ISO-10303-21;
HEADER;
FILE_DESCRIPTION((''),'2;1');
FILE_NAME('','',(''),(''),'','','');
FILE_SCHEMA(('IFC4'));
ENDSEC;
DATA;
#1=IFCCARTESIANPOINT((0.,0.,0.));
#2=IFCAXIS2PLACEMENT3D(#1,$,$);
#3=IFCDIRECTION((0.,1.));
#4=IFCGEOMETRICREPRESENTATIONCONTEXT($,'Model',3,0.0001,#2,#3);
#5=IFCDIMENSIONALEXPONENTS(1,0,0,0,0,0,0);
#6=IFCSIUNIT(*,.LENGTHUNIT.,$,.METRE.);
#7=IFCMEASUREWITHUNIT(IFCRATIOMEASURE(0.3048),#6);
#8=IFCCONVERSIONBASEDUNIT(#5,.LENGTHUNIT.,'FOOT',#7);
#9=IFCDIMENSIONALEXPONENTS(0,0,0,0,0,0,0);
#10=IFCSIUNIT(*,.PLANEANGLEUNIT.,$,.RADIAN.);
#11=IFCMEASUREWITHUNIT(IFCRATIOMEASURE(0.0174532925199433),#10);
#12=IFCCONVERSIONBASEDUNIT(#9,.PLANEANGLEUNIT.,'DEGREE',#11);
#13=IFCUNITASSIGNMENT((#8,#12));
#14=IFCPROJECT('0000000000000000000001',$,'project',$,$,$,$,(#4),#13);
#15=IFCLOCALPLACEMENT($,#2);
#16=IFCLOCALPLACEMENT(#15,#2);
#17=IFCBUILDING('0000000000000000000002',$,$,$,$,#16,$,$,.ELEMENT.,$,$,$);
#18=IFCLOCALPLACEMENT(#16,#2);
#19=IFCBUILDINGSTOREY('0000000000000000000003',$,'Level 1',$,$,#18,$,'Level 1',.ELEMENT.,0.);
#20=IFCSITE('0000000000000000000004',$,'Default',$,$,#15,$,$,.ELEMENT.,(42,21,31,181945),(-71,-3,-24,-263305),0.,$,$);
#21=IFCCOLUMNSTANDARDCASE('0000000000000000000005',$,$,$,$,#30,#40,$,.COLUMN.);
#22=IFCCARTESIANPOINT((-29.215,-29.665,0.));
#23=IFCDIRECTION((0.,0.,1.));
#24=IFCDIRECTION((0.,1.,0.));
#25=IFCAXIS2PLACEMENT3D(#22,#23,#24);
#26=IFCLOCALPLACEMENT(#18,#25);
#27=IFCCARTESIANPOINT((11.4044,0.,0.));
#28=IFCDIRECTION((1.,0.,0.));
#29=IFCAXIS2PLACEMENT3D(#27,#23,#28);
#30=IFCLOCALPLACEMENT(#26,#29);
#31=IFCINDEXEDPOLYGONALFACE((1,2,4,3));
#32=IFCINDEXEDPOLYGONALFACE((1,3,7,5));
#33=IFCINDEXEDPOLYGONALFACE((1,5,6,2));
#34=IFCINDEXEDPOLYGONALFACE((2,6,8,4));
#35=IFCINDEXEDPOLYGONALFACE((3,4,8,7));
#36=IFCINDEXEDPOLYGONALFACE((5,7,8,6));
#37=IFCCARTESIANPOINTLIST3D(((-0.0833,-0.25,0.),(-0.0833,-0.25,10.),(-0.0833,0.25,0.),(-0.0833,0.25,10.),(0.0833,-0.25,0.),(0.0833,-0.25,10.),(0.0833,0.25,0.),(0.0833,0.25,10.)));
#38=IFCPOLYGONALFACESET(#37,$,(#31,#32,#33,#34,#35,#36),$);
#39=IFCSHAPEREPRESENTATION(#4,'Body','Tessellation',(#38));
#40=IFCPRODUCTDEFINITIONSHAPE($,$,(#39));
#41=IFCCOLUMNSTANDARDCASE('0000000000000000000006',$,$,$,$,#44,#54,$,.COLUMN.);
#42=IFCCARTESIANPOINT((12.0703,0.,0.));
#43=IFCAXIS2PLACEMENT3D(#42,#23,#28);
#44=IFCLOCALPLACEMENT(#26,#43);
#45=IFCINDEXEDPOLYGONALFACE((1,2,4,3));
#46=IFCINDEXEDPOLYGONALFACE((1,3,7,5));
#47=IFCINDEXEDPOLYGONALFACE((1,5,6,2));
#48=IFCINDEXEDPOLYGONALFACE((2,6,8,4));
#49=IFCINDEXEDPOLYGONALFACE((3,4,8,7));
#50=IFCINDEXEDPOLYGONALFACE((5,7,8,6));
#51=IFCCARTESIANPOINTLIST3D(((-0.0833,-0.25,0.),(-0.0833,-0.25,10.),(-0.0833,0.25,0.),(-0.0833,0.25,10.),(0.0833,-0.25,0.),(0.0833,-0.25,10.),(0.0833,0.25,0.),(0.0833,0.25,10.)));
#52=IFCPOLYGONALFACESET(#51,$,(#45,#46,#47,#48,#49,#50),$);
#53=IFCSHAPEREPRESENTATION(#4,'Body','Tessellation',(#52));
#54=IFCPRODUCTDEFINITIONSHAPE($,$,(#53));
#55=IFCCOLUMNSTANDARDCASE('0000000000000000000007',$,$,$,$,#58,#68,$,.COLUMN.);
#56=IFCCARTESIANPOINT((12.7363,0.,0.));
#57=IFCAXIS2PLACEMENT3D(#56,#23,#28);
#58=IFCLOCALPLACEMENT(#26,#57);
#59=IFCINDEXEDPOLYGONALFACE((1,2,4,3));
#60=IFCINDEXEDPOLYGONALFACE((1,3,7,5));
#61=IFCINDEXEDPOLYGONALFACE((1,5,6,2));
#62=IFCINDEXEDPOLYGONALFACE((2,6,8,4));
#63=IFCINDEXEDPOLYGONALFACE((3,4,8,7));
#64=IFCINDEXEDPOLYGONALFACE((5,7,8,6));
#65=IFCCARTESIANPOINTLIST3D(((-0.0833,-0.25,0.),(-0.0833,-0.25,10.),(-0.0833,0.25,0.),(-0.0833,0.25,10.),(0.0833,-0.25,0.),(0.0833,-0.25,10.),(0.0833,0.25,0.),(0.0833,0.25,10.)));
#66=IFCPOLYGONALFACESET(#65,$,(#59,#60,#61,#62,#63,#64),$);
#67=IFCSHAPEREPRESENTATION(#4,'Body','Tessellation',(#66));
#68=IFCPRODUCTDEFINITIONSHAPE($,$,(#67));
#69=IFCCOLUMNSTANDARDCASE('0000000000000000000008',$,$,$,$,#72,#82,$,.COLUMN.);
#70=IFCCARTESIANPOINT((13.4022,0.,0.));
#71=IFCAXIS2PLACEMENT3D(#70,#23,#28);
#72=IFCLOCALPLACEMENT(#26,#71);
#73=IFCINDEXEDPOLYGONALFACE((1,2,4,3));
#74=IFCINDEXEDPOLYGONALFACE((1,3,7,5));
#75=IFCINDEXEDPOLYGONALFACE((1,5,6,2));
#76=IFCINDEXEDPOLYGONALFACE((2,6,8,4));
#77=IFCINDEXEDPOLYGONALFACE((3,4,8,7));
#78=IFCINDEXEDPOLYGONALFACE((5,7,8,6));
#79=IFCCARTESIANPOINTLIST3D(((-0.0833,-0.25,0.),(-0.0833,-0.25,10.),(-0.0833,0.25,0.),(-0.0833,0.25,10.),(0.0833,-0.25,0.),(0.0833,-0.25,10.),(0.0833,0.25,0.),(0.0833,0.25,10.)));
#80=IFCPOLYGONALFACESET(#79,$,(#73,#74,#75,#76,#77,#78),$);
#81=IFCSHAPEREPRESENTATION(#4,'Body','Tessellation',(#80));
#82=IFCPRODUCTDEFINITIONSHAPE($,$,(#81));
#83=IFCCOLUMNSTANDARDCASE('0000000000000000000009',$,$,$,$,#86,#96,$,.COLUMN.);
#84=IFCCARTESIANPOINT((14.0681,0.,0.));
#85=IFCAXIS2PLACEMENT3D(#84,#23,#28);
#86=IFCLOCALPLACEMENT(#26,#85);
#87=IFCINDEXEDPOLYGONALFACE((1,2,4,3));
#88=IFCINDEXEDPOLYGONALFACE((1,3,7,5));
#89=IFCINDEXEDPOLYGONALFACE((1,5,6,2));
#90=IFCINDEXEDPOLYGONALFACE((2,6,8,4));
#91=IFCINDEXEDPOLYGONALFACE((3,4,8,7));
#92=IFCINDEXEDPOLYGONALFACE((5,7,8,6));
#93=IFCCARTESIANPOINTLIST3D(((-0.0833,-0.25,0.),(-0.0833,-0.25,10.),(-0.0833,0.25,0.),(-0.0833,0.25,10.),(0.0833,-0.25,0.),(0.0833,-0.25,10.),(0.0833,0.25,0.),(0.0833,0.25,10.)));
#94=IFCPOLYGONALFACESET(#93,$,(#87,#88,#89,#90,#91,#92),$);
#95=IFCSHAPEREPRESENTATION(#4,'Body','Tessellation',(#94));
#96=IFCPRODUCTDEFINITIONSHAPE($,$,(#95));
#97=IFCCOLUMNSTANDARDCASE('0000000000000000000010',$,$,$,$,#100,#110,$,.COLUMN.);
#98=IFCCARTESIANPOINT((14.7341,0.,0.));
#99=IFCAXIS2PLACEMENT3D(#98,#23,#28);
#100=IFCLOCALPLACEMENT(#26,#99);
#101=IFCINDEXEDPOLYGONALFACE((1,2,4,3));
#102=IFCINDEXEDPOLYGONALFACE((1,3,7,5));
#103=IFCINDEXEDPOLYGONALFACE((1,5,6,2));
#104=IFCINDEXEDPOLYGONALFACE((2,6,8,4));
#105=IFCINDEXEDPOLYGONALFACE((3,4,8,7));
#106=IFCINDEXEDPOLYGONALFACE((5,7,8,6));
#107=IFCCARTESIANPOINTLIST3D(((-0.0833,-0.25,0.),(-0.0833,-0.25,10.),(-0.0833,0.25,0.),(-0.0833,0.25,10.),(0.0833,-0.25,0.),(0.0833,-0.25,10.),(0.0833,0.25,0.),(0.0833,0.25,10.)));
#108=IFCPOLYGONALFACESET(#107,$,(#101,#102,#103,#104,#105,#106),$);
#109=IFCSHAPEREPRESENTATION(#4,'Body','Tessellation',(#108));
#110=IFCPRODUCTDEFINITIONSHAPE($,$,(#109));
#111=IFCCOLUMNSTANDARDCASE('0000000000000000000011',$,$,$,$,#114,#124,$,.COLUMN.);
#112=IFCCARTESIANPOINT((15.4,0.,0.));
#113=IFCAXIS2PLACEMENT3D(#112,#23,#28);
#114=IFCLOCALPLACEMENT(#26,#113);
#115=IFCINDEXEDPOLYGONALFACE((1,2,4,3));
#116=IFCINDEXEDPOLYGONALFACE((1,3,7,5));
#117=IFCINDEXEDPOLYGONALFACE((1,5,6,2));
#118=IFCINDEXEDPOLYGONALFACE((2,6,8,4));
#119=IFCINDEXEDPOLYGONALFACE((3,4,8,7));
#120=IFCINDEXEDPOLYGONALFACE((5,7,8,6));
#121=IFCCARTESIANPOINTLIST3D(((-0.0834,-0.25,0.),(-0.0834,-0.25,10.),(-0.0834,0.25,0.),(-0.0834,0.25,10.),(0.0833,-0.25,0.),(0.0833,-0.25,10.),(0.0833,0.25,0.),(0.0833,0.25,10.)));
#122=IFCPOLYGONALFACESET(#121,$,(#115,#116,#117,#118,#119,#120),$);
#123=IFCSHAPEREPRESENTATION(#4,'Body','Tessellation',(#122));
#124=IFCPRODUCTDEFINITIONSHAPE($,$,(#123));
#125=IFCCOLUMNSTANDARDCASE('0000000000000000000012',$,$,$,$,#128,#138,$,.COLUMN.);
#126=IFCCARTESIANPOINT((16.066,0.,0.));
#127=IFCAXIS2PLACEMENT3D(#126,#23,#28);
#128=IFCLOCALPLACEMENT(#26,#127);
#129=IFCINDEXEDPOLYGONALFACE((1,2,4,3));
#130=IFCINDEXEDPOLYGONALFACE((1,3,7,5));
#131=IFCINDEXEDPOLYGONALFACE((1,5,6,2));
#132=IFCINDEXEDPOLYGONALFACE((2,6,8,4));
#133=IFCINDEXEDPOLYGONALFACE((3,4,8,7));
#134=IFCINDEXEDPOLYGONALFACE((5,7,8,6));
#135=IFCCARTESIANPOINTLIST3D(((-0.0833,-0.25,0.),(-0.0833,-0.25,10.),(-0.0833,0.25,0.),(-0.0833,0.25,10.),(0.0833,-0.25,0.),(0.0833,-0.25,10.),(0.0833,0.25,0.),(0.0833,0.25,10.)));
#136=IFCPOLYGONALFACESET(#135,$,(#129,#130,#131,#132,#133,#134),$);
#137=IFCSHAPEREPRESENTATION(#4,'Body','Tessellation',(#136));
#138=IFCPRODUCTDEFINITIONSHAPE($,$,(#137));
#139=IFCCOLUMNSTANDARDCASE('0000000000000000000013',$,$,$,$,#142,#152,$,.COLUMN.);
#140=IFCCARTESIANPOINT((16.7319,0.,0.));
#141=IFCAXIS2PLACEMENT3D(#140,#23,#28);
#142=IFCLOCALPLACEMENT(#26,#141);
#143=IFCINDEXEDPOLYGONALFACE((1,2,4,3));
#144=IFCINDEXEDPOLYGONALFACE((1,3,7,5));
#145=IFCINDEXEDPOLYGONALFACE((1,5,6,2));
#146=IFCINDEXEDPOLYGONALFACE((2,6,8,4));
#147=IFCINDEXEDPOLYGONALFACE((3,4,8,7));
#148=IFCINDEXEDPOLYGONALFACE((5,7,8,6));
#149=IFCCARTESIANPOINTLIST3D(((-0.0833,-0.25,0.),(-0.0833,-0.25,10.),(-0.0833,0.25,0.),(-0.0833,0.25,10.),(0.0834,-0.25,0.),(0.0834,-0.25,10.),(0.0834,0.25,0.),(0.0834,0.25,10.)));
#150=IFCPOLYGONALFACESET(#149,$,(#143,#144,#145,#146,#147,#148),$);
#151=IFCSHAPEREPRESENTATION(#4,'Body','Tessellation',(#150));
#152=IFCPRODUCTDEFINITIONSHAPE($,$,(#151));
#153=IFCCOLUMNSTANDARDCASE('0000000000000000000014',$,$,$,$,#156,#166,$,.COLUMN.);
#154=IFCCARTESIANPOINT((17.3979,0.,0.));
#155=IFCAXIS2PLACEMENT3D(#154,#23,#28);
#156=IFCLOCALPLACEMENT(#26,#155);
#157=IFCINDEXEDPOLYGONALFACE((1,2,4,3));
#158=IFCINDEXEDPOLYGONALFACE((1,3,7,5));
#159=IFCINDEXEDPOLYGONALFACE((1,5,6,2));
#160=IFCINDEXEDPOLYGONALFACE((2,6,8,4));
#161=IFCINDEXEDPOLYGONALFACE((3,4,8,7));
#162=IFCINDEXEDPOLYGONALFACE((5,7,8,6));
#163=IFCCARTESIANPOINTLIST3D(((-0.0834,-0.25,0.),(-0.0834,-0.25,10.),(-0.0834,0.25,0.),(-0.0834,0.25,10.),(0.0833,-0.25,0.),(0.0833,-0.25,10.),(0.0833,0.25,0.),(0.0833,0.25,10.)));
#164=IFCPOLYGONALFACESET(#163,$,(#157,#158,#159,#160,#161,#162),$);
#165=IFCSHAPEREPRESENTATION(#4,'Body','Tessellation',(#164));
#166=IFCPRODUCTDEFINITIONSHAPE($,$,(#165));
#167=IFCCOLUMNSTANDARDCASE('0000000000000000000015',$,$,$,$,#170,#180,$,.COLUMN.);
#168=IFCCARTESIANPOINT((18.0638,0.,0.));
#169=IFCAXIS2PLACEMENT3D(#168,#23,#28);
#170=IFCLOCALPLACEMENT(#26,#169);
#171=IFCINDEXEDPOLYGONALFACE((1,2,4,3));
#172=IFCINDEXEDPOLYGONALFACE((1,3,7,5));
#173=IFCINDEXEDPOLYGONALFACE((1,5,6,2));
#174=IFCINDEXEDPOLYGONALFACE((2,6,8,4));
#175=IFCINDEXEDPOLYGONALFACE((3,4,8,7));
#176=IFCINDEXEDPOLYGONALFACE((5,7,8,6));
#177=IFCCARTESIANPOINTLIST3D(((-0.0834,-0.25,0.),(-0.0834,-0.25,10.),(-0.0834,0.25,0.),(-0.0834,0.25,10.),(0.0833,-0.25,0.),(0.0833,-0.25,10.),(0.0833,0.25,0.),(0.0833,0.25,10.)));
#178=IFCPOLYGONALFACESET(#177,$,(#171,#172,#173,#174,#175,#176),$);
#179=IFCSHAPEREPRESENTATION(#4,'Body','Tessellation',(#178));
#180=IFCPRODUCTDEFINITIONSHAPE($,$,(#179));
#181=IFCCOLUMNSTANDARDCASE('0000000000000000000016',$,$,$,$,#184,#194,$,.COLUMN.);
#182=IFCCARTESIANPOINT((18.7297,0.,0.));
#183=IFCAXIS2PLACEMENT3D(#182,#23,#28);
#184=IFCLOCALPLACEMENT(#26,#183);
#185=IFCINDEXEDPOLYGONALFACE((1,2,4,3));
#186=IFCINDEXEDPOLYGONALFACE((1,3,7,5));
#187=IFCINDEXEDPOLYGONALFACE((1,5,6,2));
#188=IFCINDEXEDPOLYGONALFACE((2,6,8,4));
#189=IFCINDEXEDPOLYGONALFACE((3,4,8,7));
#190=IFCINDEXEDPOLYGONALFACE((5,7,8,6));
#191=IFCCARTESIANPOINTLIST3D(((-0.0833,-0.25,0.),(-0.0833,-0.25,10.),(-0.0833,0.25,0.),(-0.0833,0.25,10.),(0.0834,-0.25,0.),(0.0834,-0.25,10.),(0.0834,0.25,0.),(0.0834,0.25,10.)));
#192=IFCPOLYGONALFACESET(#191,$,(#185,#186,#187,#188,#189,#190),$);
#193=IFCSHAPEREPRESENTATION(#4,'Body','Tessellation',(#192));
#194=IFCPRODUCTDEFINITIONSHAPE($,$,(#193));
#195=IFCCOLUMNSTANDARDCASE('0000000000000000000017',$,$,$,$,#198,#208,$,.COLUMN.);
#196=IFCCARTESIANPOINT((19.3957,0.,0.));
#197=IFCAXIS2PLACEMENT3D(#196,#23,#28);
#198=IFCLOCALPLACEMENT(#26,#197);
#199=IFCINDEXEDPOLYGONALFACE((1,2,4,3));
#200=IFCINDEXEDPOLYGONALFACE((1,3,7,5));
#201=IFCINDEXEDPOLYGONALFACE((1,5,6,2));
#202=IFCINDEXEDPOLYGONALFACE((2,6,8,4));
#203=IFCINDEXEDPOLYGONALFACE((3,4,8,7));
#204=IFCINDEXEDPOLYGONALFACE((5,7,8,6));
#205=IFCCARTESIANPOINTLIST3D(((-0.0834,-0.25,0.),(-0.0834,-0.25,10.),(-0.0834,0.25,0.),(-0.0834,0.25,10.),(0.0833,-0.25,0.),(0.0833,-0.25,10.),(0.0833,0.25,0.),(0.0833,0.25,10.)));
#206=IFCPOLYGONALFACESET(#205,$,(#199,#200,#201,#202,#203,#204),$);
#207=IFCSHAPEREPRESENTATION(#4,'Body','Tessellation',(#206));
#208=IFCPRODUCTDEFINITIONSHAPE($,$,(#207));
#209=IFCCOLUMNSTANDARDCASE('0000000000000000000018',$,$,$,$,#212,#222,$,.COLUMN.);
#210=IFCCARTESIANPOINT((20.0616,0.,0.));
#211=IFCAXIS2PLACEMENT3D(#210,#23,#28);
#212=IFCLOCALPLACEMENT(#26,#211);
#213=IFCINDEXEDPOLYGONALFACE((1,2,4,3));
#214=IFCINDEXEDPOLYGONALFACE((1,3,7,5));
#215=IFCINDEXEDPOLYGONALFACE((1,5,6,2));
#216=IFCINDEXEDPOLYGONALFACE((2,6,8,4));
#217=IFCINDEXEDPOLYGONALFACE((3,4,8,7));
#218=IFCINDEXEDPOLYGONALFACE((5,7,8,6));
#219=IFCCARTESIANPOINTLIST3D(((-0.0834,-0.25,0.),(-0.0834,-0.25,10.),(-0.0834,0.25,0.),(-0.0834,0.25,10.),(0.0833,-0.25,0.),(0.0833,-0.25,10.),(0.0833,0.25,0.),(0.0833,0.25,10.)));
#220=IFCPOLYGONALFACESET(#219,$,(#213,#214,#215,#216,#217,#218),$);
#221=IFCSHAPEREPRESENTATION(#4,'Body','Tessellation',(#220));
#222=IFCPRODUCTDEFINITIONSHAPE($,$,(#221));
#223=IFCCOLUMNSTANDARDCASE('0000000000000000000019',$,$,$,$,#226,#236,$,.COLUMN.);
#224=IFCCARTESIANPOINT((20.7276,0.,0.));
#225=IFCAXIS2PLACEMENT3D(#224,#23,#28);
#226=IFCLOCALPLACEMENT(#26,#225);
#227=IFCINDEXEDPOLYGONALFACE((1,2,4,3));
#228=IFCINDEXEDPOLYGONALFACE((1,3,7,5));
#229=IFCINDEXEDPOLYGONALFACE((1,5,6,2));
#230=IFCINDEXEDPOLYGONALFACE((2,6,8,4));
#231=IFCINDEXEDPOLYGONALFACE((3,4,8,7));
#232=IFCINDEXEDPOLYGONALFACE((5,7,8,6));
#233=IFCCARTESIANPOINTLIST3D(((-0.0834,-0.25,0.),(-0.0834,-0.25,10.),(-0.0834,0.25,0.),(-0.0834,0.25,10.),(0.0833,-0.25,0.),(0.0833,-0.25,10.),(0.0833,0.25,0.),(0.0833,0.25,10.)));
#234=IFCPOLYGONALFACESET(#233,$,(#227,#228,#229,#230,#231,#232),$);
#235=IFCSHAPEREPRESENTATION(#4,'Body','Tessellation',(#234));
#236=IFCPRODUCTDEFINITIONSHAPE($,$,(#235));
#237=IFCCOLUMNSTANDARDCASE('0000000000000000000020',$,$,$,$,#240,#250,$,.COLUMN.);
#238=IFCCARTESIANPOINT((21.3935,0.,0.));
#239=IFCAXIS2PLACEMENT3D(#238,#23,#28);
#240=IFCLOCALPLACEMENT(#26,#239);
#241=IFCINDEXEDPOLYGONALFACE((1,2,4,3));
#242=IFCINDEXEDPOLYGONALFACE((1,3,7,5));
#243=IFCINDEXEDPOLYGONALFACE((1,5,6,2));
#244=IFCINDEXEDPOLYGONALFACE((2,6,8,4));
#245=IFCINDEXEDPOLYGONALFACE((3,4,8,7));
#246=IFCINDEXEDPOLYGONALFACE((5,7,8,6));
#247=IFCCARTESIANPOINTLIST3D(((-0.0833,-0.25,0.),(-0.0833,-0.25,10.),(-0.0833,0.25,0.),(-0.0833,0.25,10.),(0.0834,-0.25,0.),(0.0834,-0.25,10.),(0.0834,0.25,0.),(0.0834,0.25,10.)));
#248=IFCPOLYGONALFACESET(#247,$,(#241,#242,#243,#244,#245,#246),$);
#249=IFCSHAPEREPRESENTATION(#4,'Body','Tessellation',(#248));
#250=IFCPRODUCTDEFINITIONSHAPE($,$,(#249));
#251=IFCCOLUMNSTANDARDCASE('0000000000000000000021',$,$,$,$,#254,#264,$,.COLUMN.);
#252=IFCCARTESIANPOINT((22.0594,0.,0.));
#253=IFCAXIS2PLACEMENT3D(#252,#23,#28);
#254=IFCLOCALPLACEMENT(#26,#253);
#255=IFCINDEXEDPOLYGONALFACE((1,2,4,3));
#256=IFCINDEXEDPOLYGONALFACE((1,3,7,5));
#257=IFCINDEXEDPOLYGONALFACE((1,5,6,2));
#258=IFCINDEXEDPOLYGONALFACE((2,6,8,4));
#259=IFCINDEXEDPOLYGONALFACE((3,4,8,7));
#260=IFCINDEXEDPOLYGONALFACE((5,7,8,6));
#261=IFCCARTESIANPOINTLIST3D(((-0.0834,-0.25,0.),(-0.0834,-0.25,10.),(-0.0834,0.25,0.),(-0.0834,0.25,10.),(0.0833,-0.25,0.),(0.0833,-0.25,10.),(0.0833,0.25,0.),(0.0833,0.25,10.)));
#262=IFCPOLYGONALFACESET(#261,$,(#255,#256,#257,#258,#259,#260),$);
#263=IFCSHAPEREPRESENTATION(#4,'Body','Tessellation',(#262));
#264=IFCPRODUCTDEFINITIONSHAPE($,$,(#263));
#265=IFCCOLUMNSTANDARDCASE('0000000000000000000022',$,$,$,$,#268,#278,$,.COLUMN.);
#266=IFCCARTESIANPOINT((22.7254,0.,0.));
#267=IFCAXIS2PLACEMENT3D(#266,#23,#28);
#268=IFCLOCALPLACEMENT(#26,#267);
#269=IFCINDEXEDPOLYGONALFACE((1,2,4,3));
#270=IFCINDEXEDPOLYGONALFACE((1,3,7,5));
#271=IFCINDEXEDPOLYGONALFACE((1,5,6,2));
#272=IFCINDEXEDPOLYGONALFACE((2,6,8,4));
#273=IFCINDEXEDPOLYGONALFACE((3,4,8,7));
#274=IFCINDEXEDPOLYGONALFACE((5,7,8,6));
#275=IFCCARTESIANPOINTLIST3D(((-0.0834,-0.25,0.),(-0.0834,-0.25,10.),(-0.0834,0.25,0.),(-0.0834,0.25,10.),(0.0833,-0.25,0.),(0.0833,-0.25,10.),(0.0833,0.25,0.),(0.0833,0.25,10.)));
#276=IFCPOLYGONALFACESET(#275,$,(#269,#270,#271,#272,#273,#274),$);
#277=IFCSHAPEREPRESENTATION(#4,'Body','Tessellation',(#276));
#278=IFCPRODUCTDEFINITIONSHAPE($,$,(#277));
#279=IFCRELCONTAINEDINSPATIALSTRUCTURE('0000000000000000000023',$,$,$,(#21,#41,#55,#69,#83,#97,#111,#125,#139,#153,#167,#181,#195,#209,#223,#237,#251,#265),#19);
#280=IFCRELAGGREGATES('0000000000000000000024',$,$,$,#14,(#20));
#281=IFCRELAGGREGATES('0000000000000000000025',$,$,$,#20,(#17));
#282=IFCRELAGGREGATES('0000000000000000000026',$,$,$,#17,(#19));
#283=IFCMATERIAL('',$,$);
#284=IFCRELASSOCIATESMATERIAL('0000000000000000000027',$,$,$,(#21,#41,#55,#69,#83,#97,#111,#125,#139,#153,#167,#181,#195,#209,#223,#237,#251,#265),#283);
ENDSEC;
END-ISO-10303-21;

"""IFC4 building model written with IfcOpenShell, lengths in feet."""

from ifc_helpers import new_model, entity, si_unit, converted_unit, direction, frame, origin, place, context, project, spatial, rectangle, extrude, material, element, save


model = new_model("IFC4")

# Units and contexts
model_context = context("Model", 3, precision=0.0001, world=origin(), true_north=direction((0.0, 1.0)))
ifc_project = project(units=[converted_unit("LENGTHUNIT", "FOOT", entity("IfcRatioMeasure", 0.3048), si_unit("LENGTHUNIT", "METRE"), dimensions=[1, 0, 0, 0, 0, 0, 0]), converted_unit("PLANEANGLEUNIT", "DEGREE", entity("IfcRatioMeasure", 0.0174532925199433), si_unit("PLANEANGLEUNIT", "RADIAN"), dimensions=[0, 0, 0, 0, 0, 0, 0])], contexts=[model_context])

# Site, building, storey
site_placement = place(None, origin())
site = spatial("IfcSite", under=ifc_project, at=site_placement, Name="Default", CompositionType="ELEMENT", RefLatitude=(42, 21, 31, 181945), RefLongitude=(-71, -3, -24, -263305), RefElevation=0.0)
building_placement = place(site_placement, origin())
building = spatial("IfcBuilding", under=site, at=building_placement, CompositionType="ELEMENT")
storey_placement = place(building_placement, origin())
storey = spatial("IfcBuildingStorey", under=building, at=storey_placement, Name="Level 1", LongName="Level 1", CompositionType="ELEMENT", Elevation=0.0)

# Columns
ifc_material = material(Name="")
placement = place(storey_placement, frame((-29.215, -29.665, 0.0), z_axis=(0.0, 0.0, 1.0), x_axis=(0.0, 1.0, 0.0)))
for number, where, z_axis, x_axis in (
    (1, (11.4044, 0.0, 0.0), (0.0, 0.0, 1.0), (1.0, 0.0, 0.0)),
    (2, (12.0703, 0.0, 0.0), (0.0, 0.0, 1.0), (1.0, 0.0, 0.0)),
    (3, (12.7363, 0.0, 0.0), (0.0, 0.0, 1.0), (1.0, 0.0, 0.0)),
    (4, (13.4022, 0.0, 0.0), (0.0, 0.0, 1.0), (1.0, 0.0, 0.0)),
    (5, (14.0681, 0.0, 0.0), (0.0, 0.0, 1.0), (1.0, 0.0, 0.0)),
    (6, (14.7341, 0.0, 0.0), (0.0, 0.0, 1.0), (1.0, 0.0, 0.0)),
    (7, (15.4, 0.0, 0.0), (0.0, 0.0, 1.0), (1.0, 0.0, 0.0)),
    (8, (16.066, 0.0, 0.0), (0.0, 0.0, 1.0), (1.0, 0.0, 0.0)),
    (9, (16.7319, 0.0, 0.0), (0.0, 0.0, 1.0), (1.0, 0.0, 0.0)),
    (10, (17.3979, 0.0, 0.0), (0.0, 0.0, 1.0), (1.0, 0.0, 0.0)),
    (11, (18.0638, 0.0, 0.0), (0.0, 0.0, 1.0), (1.0, 0.0, 0.0)),
    (12, (18.7297, 0.0, 0.0), (0.0, 0.0, 1.0), (1.0, 0.0, 0.0)),
    (13, (19.3957, 0.0, 0.0), (0.0, 0.0, 1.0), (1.0, 0.0, 0.0)),
    (14, (20.0616, 0.0, 0.0), (0.0, 0.0, 1.0), (1.0, 0.0, 0.0)),
    (15, (20.7276, 0.0, 0.0), (0.0, 0.0, 1.0), (1.0, 0.0, 0.0)),
    (16, (21.3935, 0.0, 0.0), (0.0, 0.0, 1.0), (1.0, 0.0, 0.0)),
    (17, (22.0594, 0.0, 0.0), (0.0, 0.0, 1.0), (1.0, 0.0, 0.0)),
    (18, (22.7254, 0.0, 0.0), (0.0, 0.0, 1.0), (1.0, 0.0, 0.0)),
):
    element("IfcColumnStandardCase", number, at=place(placement, frame(where, z_axis=z_axis, x_axis=x_axis)), inside=storey, material=ifc_material, PredefinedType="COLUMN", context=model_context, shape_type="SweptSolid", body=[
        extrude(rectangle(XDim=0.1667, YDim=0.5), origin(), (0.0, 0.0, 1.0), 10.0),
    ])

save(model, "model.ifc")
